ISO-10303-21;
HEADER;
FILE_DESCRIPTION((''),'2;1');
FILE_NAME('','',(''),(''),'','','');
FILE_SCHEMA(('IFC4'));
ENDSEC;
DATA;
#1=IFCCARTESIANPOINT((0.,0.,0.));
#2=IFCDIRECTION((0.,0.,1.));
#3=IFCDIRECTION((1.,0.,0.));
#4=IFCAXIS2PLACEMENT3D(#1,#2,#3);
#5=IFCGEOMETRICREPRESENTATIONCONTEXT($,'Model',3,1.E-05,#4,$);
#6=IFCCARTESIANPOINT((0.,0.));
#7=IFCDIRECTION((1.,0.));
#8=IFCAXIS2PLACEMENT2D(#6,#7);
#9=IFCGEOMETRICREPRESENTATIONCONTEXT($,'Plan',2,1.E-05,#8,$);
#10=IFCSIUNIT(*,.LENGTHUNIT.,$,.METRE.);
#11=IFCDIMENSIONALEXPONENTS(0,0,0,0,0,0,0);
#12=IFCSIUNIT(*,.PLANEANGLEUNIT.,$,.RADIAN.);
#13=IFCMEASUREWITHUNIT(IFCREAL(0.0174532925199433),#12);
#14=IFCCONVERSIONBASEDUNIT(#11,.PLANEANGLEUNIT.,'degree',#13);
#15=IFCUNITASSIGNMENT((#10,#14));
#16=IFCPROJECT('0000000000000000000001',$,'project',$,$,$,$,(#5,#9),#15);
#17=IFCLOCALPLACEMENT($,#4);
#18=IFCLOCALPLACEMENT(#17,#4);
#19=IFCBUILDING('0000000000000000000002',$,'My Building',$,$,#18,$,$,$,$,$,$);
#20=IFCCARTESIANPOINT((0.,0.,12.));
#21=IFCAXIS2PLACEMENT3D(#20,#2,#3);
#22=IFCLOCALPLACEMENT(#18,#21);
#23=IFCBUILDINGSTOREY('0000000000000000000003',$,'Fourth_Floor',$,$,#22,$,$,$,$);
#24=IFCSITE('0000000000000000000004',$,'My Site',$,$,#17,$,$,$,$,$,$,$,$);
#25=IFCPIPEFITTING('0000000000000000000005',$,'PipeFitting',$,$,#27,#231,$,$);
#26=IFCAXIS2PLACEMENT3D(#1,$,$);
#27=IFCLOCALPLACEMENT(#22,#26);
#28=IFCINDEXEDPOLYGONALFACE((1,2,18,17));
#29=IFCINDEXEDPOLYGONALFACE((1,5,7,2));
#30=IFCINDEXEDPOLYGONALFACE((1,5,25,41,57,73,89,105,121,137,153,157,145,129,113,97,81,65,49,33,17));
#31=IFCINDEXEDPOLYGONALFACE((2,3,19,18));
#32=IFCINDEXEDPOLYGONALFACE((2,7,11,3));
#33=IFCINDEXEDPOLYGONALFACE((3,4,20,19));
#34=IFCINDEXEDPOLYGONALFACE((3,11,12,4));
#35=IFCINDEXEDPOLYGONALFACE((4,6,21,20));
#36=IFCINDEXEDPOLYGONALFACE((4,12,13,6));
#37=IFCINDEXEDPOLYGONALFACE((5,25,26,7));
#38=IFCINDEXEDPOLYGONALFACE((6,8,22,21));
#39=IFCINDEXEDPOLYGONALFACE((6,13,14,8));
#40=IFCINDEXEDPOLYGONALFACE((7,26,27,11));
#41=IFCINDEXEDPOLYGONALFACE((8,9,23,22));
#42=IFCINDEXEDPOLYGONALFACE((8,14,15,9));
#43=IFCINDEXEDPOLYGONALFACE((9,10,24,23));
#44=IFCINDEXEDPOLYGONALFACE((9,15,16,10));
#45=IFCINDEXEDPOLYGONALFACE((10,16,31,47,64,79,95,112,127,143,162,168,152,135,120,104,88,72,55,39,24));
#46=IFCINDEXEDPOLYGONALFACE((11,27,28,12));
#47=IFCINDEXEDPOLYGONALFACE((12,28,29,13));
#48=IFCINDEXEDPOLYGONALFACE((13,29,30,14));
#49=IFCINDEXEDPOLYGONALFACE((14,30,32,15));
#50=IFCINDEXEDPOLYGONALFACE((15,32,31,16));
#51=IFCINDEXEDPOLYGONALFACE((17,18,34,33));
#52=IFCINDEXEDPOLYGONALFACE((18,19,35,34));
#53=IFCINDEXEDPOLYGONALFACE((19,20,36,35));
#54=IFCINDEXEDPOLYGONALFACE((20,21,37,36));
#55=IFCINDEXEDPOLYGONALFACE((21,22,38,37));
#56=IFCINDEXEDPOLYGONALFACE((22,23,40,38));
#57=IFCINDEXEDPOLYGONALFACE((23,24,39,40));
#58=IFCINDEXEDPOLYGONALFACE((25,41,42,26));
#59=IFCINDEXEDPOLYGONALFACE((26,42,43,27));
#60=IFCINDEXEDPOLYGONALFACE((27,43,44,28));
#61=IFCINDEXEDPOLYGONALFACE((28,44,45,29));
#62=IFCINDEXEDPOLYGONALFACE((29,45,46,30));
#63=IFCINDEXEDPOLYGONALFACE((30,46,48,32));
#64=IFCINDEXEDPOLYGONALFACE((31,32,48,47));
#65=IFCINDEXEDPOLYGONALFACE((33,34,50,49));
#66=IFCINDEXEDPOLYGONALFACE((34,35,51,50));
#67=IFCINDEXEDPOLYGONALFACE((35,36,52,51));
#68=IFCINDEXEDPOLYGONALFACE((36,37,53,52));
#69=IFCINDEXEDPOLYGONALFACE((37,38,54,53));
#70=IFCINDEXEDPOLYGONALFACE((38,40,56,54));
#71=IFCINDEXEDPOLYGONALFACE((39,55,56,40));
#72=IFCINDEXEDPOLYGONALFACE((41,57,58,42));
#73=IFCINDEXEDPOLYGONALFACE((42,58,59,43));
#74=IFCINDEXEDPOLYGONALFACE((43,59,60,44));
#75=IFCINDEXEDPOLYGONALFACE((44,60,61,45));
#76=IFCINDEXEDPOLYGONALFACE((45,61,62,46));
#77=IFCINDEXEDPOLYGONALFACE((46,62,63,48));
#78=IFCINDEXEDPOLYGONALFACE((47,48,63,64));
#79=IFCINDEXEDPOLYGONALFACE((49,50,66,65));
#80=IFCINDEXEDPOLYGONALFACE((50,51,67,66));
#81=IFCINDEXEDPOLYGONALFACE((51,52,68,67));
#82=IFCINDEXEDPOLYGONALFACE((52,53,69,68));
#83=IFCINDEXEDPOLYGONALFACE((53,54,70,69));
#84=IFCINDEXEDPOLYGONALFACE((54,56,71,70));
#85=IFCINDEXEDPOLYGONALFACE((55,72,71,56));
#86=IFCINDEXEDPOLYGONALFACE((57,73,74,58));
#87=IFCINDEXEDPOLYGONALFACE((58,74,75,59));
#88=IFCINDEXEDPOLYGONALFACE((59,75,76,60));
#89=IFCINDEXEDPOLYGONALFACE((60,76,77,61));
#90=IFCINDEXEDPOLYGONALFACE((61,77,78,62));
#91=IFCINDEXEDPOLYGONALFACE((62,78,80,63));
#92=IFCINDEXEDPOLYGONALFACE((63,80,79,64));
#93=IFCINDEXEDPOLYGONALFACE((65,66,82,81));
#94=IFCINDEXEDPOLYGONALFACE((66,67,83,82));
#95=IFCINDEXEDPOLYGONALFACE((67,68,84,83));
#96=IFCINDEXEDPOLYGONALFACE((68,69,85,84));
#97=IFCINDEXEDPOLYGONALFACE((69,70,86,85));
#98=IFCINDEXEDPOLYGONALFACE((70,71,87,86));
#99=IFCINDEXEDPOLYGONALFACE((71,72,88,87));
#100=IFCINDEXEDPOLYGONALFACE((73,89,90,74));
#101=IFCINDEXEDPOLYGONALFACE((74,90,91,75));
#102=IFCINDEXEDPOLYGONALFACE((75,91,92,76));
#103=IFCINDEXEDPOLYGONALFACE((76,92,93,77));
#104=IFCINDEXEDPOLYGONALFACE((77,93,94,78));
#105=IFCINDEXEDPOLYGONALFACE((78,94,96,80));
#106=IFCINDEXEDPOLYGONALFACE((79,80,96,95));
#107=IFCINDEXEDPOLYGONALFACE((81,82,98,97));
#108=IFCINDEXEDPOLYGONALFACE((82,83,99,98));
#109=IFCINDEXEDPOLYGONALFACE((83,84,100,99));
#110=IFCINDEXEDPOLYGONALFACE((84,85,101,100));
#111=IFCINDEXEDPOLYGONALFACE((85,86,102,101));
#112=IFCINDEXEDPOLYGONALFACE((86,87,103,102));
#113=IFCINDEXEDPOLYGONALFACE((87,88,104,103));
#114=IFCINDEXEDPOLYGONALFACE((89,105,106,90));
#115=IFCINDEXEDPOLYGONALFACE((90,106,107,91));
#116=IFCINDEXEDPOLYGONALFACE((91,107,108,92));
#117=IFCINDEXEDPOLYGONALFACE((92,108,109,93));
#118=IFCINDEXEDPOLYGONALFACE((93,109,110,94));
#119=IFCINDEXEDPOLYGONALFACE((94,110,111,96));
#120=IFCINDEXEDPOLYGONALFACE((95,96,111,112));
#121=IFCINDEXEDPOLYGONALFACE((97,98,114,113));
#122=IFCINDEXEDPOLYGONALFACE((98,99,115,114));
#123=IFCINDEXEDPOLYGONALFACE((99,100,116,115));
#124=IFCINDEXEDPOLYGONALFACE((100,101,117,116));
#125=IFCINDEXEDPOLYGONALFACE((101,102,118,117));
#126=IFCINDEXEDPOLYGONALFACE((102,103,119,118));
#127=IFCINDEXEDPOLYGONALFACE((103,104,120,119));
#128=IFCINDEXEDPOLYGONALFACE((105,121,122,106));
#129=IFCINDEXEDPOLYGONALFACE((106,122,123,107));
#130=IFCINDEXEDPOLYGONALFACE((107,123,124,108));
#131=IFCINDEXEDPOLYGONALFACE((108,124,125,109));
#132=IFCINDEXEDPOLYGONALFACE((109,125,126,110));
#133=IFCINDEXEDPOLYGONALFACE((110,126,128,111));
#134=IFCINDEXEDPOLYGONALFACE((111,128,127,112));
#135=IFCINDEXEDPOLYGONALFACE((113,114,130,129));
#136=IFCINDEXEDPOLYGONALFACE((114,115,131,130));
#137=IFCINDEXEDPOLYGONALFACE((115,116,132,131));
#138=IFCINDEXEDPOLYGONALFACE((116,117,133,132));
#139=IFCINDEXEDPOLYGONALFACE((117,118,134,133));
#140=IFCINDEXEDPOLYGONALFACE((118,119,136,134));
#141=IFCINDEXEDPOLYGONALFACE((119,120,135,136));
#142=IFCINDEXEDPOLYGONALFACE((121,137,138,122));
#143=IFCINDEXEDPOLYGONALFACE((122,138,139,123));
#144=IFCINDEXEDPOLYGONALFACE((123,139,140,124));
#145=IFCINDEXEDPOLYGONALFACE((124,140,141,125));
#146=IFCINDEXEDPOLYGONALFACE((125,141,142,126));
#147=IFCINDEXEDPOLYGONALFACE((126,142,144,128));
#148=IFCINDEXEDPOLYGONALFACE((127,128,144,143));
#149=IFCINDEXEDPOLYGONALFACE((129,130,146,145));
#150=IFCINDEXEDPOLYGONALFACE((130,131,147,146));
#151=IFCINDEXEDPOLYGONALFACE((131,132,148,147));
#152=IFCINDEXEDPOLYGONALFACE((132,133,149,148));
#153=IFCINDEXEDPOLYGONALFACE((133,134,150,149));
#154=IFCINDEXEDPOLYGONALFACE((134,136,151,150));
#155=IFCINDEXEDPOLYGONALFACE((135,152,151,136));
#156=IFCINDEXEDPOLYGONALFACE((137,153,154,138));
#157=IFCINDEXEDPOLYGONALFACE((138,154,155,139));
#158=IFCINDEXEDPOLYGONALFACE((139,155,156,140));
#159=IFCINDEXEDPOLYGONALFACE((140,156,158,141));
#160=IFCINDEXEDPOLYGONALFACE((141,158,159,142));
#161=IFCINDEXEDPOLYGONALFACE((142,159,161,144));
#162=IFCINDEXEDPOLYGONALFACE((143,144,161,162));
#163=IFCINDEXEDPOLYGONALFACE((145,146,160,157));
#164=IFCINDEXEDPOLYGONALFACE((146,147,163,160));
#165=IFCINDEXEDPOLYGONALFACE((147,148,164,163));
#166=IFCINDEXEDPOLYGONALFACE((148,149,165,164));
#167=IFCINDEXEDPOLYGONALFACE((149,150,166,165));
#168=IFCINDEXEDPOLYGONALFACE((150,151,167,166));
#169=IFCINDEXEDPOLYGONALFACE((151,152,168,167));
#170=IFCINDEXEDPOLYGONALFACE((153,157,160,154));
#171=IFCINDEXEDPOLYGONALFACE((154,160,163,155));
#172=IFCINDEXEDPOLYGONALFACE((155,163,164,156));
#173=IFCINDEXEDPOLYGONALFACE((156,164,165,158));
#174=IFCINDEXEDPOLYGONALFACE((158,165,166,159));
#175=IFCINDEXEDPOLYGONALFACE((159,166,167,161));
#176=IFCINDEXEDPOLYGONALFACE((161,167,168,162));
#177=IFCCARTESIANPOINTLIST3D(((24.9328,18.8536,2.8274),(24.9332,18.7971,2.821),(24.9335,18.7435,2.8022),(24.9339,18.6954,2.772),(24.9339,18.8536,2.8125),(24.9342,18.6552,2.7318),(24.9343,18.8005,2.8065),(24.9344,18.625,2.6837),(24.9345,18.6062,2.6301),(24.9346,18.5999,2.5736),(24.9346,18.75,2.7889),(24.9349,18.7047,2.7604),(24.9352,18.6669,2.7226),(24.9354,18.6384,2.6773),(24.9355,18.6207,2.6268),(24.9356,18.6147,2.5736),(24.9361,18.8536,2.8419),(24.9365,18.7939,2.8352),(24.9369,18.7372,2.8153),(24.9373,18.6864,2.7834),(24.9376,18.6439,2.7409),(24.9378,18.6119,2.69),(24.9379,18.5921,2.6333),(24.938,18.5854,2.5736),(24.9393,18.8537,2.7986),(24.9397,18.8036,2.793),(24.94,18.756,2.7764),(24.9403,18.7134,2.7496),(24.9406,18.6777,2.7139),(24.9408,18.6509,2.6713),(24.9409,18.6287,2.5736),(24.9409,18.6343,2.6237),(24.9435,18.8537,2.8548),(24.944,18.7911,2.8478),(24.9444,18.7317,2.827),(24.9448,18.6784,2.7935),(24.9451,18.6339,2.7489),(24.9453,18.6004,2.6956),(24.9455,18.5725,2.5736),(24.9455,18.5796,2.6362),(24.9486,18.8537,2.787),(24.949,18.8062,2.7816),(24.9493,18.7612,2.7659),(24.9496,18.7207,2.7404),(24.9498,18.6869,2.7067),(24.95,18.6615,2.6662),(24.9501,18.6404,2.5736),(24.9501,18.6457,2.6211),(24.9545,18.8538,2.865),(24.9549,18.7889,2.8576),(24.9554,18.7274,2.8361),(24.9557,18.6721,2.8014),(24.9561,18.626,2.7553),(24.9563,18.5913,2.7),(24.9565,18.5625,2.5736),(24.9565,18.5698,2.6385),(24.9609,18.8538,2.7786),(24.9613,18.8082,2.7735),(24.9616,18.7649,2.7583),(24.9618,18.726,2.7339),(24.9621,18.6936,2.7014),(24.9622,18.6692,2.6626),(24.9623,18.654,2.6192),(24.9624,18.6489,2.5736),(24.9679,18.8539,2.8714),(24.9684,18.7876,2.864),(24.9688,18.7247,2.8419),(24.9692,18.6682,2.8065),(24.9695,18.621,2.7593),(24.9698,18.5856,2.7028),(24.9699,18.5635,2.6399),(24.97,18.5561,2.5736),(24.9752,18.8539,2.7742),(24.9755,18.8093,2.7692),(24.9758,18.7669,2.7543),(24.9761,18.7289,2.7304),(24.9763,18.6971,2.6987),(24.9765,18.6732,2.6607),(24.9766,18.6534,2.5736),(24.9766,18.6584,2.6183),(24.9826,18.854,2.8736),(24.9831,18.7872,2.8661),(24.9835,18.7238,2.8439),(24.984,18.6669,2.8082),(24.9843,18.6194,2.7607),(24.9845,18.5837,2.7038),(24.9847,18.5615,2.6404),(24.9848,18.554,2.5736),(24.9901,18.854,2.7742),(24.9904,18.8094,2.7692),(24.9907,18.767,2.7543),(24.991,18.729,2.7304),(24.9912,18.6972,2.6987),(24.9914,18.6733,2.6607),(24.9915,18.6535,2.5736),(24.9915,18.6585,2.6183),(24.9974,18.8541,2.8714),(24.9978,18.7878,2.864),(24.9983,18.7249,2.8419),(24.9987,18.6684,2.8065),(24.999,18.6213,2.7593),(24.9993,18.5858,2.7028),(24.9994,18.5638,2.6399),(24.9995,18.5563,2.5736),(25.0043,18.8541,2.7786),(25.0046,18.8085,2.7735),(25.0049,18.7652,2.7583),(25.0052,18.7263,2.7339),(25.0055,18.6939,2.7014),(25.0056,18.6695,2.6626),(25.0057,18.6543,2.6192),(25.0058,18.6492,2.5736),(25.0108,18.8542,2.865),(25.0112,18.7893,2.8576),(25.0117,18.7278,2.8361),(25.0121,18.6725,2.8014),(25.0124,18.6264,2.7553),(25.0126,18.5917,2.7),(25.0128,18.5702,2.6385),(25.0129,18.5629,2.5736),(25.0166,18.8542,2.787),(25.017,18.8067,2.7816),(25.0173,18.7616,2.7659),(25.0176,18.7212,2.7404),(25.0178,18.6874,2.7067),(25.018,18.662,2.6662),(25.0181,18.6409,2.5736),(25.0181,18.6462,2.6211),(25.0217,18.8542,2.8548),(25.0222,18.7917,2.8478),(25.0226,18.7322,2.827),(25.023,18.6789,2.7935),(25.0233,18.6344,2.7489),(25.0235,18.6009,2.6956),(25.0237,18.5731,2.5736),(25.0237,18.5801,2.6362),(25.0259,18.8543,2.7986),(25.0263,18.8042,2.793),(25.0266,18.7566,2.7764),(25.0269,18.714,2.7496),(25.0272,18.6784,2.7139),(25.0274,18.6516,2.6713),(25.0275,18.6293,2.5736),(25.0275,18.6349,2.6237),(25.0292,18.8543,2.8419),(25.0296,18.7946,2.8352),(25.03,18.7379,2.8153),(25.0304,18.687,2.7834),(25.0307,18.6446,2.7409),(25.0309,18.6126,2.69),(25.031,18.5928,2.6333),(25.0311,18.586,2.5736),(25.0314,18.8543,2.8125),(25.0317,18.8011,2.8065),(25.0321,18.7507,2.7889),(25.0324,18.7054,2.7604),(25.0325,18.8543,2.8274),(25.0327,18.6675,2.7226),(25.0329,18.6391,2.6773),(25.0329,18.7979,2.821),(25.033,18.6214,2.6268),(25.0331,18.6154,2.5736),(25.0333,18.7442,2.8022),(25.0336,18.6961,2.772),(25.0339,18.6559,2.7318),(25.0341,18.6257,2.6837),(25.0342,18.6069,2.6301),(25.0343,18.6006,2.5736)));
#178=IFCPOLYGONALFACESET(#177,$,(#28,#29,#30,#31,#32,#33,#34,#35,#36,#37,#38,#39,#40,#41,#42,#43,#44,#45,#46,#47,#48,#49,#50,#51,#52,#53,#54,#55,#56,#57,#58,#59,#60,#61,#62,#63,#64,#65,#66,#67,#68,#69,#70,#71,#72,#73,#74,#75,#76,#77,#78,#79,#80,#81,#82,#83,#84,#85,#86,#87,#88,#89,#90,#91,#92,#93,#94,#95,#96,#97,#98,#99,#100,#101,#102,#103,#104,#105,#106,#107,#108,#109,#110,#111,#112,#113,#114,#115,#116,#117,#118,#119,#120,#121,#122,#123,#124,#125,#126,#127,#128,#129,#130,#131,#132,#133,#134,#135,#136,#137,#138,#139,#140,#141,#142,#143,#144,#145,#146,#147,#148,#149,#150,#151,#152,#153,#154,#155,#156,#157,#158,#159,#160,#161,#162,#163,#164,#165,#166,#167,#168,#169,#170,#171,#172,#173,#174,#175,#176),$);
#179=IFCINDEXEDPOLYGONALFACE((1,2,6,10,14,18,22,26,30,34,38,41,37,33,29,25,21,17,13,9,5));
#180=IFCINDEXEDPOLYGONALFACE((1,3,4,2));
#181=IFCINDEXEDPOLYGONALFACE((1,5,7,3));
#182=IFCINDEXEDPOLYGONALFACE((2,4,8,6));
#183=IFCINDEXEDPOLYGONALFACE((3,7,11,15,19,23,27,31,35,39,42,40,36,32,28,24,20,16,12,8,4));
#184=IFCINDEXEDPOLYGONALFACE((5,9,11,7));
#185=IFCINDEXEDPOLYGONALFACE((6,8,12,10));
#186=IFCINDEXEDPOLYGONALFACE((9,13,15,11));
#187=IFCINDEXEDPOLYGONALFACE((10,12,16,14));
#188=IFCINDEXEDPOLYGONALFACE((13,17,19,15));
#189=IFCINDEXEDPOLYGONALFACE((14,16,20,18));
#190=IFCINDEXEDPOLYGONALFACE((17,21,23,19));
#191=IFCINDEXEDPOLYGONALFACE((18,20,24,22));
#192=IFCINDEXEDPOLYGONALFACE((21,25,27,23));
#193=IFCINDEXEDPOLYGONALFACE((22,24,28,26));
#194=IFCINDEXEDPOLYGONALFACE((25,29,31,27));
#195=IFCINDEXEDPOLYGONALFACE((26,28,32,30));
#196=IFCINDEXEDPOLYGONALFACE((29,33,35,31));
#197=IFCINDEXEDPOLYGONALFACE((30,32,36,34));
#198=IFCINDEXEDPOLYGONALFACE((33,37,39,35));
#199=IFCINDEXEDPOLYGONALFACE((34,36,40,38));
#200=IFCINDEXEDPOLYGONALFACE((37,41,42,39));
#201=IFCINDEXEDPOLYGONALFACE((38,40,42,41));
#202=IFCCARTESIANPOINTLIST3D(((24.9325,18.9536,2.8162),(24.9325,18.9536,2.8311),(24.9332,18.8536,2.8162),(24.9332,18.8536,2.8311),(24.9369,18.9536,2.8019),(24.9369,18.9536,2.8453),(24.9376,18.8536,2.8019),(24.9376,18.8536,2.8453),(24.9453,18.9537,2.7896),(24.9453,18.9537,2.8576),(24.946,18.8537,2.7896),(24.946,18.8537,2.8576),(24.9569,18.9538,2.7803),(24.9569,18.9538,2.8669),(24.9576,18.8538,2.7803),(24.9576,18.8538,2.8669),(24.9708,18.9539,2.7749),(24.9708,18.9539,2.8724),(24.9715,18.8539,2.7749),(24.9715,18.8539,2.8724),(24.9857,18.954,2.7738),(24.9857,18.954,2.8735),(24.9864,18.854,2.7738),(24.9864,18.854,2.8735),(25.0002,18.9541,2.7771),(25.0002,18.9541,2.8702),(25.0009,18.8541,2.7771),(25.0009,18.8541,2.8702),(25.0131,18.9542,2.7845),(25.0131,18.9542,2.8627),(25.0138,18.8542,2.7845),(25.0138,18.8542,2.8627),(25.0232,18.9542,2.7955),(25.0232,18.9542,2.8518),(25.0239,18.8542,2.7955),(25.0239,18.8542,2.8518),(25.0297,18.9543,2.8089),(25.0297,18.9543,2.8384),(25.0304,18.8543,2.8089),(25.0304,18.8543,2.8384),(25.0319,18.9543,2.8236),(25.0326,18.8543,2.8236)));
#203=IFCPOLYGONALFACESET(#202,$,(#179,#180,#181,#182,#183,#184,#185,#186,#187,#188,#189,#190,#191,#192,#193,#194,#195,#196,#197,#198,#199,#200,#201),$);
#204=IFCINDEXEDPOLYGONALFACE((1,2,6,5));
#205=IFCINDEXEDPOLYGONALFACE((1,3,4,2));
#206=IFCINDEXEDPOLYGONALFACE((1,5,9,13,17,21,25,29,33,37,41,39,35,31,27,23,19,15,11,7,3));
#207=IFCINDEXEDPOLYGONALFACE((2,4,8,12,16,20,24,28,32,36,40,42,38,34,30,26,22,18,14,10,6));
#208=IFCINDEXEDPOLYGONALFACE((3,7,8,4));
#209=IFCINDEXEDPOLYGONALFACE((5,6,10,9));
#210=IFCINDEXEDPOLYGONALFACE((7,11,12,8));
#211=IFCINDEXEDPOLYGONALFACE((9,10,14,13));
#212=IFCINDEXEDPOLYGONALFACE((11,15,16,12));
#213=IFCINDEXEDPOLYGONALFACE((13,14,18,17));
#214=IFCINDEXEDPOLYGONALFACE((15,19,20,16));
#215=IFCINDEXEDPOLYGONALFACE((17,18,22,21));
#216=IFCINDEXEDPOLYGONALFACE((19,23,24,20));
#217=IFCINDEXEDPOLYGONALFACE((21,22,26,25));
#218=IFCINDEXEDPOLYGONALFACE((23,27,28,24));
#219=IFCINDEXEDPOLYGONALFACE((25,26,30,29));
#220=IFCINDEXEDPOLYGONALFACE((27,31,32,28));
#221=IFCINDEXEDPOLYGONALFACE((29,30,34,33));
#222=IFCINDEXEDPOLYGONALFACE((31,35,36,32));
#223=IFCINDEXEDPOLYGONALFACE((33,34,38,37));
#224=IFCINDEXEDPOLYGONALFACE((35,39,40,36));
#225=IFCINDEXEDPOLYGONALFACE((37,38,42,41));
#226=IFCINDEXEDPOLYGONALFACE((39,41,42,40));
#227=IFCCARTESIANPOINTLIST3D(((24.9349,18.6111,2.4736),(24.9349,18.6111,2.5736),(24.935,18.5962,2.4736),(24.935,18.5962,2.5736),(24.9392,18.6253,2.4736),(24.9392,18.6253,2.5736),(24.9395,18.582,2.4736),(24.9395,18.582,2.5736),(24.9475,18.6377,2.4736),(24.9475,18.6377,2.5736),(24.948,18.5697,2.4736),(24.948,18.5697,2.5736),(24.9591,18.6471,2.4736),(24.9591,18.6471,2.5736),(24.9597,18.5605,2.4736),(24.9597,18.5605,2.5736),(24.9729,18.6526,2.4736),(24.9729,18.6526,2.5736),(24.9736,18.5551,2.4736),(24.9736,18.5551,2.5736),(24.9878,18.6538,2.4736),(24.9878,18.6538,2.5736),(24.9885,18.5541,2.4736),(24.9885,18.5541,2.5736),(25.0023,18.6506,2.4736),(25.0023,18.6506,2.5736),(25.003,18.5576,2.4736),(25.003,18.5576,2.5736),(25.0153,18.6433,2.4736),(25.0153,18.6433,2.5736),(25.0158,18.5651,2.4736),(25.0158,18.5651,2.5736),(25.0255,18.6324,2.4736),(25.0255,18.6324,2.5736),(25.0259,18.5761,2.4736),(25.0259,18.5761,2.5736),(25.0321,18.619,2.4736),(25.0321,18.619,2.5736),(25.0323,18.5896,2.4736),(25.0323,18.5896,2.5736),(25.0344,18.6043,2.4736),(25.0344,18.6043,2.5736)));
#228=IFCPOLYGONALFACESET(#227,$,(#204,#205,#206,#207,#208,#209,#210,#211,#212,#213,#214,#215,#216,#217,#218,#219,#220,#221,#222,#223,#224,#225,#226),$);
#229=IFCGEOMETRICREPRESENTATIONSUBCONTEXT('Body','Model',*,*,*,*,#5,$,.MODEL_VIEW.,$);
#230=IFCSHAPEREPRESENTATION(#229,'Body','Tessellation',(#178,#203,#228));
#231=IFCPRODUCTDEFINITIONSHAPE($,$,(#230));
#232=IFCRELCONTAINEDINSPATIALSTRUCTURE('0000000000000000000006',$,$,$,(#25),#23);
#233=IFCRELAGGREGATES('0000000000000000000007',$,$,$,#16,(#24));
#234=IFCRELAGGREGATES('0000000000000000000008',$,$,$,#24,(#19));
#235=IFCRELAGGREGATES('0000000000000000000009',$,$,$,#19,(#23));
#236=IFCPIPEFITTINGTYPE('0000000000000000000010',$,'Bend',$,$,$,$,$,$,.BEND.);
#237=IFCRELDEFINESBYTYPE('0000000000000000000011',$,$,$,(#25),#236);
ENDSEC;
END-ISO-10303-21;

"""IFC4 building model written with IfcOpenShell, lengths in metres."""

from ifc_helpers import new_model, entity, si_unit, converted_unit, frame, origin_with_axes, origin_2d_with_axis, place, context, subcontext, project, spatial, circle, extrude, source, transform, mapped, type_object, type_shapes, element, save


model = new_model("IFC4")

# Units and contexts
model_context = context("Model", 3, precision=1e-05, world=origin_with_axes())
plan_context = context("Plan", 2, precision=1e-05, world=origin_2d_with_axis())
body_context_1 = subcontext(model_context, "Body", "Model", "MODEL_VIEW")
ifc_project = project(units=[si_unit("LENGTHUNIT", "METRE"), converted_unit("PLANEANGLEUNIT", "degree", entity("IfcReal", 0.0174532925199433), si_unit("PLANEANGLEUNIT", "RADIAN"), dimensions=[0, 0, 0, 0, 0, 0, 0])], contexts=[model_context, plan_context])

# Site, building, storey
site_placement = place(None, origin_with_axes())
site = spatial("IfcSite", under=ifc_project, at=site_placement, Name="My Site")
building_placement = place(site_placement, origin_with_axes())
building = spatial("IfcBuilding", under=site, at=building_placement, Name="My Building")
storey_placement = place(building_placement, frame((0.0, 0.0, 12.0), z_axis=(0.0, 0.0, 1.0), x_axis=(1.0, 0.0, 0.0)))
storey = spatial("IfcBuildingStorey", under=building, at=storey_placement, Name="Fourth_Floor")

# Pipe fitting
pipe_fitting_type = type_object("IfcPipeFittingType", Name="Bend", PredefinedType="BEND")
shared_shape_1 = source(origin_with_axes(), body_context_1, "Body", "SolidModel", [
    entity("IfcSweptDiskSolid", entity("IfcIndexedPolyCurve", entity("IfcCartesianPointList3D", [[0.0, 0.0, -0.1], [0.0, 0.0732, -0.2768], [0.0, 0.25, -0.35]]), [entity("IfcArcIndex", [1, 2, 3])]), 0.05),
    extrude(circle(Radius=0.05), origin_with_axes(), (0.0, 0.0, -1.0), 0.1),
    extrude(circle(Radius=0.05), frame((0.0, 0.25, -0.35), z_axis=(0.0, 1.0, 0.0), x_axis=(1.0, 0.0, 0.0)), (0.0, 0.0, 1.0), 0.1),
])
type_shapes(pipe_fitting_type, [shared_shape_1])
for number, where, z_axis, x_axis, name in (
    (1, (24.9819, 18.954, 2.8236), (-0.007084, 0.999975, 0.0), (0.999975, 0.007084, 0.0), "PipeFitting"),
):
    element("IfcPipeFitting", number, at=place(storey_placement, frame(where, z_axis=z_axis, x_axis=x_axis)), inside=storey, type_object=pipe_fitting_type, Name=name, context=body_context_1, shape_type="MappedRepresentation", body=[
        mapped(shared_shape_1, transform((0.0, 0.0, 0.0), x_axis=(1.0, 0.0, 0.0), y_axis=(0.0, 1.0, 0.0), z_axis=(0.0, 0.0, 1.0), scale=1.0)),
    ])

save(model, "model.ifc")
